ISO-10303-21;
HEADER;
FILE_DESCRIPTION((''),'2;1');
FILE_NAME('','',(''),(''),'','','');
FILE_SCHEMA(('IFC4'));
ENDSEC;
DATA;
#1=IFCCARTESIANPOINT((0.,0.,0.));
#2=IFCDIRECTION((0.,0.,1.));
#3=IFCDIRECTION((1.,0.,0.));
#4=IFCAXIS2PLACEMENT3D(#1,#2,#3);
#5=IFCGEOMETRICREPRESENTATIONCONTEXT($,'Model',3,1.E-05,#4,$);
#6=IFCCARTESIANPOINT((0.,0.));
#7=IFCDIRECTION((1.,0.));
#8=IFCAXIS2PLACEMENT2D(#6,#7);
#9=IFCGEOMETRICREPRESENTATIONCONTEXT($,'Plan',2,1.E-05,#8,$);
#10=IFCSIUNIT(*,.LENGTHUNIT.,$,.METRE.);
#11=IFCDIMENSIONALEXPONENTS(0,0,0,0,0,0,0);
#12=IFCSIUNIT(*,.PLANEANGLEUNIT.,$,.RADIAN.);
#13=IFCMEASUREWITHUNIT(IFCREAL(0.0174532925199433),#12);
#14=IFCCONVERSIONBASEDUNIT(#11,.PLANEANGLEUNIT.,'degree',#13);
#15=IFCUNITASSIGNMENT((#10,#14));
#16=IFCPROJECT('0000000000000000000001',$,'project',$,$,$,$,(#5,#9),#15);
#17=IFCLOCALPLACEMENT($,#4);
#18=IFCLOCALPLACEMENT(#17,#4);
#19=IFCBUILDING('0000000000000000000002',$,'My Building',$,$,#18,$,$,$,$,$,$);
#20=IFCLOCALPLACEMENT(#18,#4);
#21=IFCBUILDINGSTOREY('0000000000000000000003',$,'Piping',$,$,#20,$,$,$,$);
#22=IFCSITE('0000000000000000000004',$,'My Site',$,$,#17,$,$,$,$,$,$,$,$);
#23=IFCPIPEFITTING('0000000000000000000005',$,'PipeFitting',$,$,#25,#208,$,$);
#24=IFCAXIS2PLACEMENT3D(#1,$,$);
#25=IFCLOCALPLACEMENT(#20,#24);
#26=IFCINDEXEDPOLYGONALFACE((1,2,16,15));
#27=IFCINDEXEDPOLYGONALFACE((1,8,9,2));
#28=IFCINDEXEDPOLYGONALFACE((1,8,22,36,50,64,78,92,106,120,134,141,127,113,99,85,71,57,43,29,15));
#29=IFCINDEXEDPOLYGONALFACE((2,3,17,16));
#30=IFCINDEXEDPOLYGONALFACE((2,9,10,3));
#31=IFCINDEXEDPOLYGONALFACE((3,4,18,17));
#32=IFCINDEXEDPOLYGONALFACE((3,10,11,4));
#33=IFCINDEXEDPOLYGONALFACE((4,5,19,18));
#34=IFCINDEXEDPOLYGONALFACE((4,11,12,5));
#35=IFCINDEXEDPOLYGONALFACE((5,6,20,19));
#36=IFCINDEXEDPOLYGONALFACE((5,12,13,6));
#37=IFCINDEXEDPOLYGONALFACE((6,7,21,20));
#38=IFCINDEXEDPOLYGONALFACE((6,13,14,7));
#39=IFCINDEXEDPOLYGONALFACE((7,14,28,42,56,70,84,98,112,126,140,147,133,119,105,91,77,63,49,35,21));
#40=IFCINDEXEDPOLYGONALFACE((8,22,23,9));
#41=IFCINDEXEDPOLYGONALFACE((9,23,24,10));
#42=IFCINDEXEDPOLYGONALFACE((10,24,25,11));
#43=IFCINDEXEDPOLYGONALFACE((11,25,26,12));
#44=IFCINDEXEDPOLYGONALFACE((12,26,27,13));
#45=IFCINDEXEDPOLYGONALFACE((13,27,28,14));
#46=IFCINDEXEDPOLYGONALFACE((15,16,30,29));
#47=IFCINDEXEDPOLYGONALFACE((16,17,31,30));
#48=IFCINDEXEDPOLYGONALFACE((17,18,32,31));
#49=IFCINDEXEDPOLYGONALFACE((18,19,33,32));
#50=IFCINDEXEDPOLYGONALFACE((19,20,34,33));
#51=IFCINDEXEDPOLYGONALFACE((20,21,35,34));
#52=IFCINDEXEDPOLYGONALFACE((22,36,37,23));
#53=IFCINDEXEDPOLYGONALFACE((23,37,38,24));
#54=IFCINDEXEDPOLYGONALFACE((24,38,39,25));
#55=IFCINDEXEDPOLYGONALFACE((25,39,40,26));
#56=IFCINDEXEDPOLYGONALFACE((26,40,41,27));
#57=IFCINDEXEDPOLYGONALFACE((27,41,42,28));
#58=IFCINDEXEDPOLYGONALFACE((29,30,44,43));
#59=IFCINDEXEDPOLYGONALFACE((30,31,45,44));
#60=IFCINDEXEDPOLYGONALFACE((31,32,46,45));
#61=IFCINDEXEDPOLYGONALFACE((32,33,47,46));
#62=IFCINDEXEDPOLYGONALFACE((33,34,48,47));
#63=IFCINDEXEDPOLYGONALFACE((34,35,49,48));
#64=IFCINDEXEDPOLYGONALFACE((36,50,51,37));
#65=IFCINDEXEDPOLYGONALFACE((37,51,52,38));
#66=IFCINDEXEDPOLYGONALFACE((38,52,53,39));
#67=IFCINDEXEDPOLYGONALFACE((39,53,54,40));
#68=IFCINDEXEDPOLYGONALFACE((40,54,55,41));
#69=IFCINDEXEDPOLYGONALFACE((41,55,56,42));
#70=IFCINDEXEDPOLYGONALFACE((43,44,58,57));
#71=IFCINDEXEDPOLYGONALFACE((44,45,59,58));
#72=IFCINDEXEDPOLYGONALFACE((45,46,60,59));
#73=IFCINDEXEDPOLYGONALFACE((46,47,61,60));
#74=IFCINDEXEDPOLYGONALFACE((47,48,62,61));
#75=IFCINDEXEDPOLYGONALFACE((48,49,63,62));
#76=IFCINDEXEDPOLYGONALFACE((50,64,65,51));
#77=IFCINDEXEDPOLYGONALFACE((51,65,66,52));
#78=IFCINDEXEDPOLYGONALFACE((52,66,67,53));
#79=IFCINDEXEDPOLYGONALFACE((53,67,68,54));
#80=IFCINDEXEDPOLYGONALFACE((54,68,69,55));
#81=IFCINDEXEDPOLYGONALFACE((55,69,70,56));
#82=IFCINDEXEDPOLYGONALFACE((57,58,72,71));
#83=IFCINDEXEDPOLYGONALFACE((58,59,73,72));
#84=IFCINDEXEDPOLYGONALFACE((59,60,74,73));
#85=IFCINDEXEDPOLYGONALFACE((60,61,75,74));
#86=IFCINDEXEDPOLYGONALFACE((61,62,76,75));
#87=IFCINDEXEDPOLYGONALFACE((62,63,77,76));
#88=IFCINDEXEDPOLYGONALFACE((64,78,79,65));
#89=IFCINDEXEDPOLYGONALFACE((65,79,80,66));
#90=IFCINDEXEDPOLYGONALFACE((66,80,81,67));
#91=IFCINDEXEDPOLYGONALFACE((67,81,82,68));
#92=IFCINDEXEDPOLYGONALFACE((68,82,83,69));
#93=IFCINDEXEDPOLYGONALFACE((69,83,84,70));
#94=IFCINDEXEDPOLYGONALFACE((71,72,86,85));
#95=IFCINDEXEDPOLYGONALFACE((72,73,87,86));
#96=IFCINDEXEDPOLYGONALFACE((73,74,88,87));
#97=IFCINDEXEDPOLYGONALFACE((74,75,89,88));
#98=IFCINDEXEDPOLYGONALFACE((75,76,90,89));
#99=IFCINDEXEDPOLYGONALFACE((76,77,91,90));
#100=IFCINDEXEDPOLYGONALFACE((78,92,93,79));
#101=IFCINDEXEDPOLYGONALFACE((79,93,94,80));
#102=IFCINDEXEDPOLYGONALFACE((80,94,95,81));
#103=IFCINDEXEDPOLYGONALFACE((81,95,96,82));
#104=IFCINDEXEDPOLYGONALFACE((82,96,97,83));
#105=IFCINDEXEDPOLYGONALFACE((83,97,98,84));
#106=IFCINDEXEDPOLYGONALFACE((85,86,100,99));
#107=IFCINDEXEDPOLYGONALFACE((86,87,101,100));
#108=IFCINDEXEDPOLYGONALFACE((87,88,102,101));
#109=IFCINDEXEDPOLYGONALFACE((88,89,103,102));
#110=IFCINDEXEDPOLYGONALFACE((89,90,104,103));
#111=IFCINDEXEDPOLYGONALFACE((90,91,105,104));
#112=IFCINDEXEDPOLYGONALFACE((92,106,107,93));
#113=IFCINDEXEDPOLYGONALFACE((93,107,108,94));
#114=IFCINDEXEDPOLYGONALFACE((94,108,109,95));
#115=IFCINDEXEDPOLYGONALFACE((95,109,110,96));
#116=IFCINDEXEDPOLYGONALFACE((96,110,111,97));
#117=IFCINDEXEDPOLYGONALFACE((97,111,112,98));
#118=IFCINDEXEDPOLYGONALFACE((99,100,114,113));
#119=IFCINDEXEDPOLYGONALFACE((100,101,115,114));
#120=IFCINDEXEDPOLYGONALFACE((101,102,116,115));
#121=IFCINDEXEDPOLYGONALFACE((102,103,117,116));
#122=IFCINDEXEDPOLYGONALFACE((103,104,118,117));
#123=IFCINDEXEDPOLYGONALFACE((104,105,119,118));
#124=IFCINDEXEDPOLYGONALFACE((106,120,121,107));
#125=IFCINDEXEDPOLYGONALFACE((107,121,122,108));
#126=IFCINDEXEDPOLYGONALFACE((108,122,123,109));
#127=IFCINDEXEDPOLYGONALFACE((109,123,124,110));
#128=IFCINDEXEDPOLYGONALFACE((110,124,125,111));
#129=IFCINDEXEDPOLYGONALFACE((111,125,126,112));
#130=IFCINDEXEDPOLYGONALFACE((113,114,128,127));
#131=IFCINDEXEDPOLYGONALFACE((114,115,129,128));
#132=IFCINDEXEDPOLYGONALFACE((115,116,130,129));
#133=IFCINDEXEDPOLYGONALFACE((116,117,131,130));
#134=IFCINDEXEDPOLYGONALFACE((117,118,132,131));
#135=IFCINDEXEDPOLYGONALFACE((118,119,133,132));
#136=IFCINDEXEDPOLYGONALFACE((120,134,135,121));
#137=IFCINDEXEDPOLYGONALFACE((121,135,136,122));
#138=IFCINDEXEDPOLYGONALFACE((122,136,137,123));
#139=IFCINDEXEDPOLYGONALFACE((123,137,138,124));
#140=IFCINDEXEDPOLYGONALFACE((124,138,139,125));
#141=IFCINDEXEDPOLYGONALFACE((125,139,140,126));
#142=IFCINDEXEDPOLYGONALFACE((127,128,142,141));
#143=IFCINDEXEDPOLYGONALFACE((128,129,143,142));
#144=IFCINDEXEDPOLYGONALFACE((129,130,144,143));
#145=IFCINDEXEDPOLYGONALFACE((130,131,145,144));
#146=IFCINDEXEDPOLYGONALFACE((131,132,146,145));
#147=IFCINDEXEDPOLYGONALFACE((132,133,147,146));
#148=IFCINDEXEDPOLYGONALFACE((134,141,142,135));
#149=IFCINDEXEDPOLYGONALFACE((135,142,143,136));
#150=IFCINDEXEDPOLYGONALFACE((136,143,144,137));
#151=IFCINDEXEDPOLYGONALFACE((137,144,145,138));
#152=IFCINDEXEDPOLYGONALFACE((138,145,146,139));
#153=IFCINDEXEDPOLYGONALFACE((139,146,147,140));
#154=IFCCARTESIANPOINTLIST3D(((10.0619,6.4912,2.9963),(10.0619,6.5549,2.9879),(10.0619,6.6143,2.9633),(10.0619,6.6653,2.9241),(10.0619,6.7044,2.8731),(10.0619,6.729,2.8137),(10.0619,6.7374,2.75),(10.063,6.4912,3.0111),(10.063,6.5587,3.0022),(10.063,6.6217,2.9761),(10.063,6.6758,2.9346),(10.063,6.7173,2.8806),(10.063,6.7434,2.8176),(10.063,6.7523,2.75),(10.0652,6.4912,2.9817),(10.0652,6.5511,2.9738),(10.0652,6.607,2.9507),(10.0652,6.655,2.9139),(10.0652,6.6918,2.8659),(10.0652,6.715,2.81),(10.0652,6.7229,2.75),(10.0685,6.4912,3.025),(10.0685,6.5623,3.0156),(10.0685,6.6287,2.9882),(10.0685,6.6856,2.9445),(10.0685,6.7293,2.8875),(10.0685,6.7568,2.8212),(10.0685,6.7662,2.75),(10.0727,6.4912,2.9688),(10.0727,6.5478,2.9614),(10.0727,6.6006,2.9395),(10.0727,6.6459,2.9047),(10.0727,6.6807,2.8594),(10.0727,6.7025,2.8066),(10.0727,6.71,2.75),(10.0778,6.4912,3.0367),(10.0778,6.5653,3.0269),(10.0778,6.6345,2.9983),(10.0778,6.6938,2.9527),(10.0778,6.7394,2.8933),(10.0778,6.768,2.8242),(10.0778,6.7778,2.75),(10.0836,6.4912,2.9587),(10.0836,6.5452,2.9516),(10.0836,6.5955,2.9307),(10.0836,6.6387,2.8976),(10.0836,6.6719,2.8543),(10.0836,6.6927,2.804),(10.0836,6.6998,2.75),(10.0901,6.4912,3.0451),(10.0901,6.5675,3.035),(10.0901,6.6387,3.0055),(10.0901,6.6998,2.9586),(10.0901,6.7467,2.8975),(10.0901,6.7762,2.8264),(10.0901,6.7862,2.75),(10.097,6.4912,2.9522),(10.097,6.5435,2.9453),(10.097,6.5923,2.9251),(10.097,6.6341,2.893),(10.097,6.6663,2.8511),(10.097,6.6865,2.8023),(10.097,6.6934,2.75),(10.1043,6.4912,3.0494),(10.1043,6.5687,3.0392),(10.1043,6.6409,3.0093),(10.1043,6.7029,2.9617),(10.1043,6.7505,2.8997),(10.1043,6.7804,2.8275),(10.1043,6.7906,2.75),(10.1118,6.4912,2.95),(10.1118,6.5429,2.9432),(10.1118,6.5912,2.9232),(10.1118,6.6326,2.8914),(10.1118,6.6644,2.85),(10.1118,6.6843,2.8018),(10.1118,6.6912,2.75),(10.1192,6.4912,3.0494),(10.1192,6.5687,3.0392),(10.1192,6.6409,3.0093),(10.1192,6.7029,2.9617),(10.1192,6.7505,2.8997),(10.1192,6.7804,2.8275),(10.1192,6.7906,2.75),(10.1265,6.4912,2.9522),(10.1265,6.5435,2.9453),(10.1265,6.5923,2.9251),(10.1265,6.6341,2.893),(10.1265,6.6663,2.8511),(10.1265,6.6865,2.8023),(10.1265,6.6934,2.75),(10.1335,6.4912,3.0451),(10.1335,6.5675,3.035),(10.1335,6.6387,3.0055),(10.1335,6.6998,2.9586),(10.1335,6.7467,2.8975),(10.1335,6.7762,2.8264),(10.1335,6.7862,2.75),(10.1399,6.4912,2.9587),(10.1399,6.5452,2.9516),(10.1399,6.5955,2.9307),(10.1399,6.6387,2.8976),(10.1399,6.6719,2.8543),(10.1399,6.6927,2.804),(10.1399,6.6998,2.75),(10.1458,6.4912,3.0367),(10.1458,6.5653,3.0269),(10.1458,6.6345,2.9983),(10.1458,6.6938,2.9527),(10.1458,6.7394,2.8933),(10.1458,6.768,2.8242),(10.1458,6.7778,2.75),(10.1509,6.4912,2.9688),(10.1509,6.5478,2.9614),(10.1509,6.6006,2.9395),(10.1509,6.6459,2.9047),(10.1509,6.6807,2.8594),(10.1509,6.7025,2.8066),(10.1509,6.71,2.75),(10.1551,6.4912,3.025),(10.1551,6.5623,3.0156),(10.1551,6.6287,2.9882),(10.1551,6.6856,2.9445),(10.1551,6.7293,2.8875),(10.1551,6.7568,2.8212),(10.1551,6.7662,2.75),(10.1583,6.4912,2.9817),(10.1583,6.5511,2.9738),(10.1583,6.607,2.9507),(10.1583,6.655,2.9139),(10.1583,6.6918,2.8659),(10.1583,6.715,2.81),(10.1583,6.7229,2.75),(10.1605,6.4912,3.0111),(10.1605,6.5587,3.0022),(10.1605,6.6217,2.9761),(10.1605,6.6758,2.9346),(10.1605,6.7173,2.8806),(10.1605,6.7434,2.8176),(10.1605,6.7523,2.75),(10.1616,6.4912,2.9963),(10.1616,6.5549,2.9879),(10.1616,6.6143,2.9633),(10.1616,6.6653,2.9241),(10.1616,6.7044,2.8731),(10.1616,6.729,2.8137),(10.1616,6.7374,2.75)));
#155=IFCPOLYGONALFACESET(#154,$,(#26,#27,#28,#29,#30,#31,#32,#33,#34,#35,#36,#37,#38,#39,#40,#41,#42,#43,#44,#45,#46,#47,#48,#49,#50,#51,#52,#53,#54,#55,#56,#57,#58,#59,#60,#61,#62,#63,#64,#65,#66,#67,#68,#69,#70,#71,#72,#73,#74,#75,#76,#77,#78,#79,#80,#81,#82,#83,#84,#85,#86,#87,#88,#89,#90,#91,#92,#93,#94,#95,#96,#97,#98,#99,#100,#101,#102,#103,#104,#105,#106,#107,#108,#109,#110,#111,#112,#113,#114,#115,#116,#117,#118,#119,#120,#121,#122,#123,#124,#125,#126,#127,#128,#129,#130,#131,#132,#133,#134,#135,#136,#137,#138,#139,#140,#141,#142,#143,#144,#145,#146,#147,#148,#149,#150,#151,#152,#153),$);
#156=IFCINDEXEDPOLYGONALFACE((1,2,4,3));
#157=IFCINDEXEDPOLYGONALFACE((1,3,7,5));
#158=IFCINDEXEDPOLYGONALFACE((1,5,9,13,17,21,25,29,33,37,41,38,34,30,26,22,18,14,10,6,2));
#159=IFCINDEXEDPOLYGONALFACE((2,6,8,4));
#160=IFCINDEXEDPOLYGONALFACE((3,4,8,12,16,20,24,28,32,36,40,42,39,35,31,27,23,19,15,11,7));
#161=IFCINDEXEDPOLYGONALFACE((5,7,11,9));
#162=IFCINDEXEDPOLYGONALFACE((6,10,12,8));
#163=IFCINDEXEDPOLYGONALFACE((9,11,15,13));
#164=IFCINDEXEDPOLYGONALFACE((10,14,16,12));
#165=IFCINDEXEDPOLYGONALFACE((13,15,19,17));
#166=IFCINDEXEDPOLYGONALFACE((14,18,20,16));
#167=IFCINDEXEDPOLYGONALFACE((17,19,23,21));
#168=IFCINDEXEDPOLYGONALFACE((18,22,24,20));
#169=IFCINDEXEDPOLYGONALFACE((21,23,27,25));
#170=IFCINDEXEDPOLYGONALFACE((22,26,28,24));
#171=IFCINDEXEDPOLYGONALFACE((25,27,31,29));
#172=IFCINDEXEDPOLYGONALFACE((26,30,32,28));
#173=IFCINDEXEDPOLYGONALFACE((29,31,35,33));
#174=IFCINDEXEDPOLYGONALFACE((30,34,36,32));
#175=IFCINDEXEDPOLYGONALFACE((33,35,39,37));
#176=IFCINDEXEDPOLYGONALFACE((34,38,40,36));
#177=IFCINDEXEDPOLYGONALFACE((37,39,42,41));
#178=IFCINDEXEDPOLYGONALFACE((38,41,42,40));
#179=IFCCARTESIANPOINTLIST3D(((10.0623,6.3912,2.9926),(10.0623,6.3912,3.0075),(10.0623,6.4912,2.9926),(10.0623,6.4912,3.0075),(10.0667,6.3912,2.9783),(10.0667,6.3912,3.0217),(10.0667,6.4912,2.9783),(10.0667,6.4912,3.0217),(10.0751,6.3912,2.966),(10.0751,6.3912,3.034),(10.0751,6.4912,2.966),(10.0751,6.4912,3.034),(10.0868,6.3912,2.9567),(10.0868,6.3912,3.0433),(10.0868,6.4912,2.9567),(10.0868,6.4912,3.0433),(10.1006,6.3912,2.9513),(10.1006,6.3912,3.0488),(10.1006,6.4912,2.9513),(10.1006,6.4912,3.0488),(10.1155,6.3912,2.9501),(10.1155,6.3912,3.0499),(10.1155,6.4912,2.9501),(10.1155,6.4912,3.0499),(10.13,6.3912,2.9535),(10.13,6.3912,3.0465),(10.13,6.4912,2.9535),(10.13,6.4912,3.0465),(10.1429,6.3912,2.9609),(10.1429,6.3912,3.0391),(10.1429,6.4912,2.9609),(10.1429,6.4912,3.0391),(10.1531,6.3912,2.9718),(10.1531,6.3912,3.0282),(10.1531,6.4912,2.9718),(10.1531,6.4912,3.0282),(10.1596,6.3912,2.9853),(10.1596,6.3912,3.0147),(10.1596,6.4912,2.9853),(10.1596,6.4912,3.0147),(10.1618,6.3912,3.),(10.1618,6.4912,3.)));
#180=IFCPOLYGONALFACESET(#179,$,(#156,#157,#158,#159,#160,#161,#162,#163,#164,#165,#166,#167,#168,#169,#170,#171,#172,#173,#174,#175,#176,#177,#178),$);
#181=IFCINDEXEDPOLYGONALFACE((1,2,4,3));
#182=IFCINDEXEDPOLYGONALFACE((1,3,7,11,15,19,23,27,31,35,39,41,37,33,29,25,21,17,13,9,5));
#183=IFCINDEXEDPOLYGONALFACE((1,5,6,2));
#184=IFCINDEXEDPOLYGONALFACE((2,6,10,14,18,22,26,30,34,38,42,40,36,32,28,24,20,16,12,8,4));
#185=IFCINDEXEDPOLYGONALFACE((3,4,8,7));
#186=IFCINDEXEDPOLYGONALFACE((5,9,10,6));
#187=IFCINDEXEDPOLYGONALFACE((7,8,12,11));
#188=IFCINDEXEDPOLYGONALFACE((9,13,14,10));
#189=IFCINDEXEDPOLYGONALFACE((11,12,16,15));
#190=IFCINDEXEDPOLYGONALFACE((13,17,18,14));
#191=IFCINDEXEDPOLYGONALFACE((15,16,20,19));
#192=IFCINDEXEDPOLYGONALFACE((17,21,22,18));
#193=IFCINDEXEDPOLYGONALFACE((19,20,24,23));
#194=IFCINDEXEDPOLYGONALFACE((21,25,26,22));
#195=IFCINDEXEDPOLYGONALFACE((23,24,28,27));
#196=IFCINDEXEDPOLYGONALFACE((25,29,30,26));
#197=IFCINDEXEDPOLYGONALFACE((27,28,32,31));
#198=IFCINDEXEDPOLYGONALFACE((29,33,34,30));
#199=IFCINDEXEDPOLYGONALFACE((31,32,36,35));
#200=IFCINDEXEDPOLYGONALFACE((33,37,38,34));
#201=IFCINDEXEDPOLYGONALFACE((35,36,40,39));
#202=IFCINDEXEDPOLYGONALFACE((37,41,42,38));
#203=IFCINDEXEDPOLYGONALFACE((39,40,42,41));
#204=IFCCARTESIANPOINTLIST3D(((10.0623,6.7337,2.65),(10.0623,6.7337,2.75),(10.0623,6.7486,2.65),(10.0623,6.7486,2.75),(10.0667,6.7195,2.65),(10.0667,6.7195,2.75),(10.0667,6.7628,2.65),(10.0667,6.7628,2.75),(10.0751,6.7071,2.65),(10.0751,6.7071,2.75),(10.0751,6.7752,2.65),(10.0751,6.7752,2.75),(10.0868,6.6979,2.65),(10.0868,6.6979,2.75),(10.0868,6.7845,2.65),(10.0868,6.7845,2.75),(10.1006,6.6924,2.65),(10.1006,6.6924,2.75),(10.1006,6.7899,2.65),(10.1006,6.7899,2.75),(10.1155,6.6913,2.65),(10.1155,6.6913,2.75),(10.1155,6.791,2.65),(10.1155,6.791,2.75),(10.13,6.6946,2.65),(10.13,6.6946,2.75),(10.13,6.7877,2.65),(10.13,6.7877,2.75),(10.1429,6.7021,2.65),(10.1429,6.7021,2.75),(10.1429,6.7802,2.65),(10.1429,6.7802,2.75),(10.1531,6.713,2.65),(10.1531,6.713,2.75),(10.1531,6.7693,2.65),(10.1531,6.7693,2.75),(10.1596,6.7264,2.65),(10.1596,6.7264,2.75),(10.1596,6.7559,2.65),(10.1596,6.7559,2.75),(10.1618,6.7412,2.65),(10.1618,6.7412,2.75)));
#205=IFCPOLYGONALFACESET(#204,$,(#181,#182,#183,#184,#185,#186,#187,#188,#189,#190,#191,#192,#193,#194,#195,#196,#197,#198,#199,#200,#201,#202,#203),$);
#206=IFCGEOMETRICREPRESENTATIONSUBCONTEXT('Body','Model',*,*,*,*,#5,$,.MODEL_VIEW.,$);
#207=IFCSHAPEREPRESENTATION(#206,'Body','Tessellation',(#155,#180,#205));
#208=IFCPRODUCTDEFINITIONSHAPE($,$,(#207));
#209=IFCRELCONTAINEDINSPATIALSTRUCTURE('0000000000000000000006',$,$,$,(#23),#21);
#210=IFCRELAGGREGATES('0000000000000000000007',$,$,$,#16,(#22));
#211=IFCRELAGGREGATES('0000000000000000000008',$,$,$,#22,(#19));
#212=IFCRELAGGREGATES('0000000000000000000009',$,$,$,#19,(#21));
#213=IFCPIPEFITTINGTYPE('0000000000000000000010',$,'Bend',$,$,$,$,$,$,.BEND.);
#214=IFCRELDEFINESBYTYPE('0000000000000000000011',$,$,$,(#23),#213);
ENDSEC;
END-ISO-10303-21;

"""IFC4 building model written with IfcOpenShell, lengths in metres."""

from ifc_helpers import new_model, entity, si_unit, converted_unit, frame, origin_with_axes, origin_2d_with_axis, place, context, subcontext, project, spatial, circle, extrude, source, transform, mapped, type_object, type_shapes, element, save


model = new_model("IFC4")

# Units and contexts
model_context = context("Model", 3, precision=1e-05, world=origin_with_axes())
plan_context = context("Plan", 2, precision=1e-05, world=origin_2d_with_axis())
body_context = subcontext(model_context, "Body", "Model", "MODEL_VIEW")
ifc_project = project(units=[si_unit("LENGTHUNIT", "METRE"), converted_unit("PLANEANGLEUNIT", "degree", entity("IfcReal", 0.0174532925199433), si_unit("PLANEANGLEUNIT", "RADIAN"), dimensions=[0, 0, 0, 0, 0, 0, 0])], contexts=[model_context, plan_context])

# Site, building, storey
site_placement = place(None, origin_with_axes())
site = spatial("IfcSite", under=ifc_project, at=site_placement, Name="My Site")
building_placement = place(site_placement, origin_with_axes())
building = spatial("IfcBuilding", under=site, at=building_placement, Name="My Building")
storey_placement = place(building_placement, origin_with_axes())
storey = spatial("IfcBuildingStorey", under=building, at=storey_placement, Name="Piping")

# Pipe fitting
pipe_fitting_type = type_object("IfcPipeFittingType", Name="Bend", PredefinedType="BEND")
shared_shape = source(origin_with_axes(), body_context, "Body", "SolidModel", [
    entity("IfcSweptDiskSolid", entity("IfcIndexedPolyCurve", entity("IfcCartesianPointList3D", [[0.0, 0.0, -0.1], [0.0, -0.0732, -0.2768], [0.0, -0.25, -0.35]]), [entity("IfcArcIndex", [1, 2, 3])]), 0.05),
    extrude(circle(Radius=0.05), origin_with_axes(), (0.0, 0.0, -1.0), 0.1),
    extrude(circle(Radius=0.05), frame((0.0, -0.25, -0.35), z_axis=(0.0, -1.0, 0.0), x_axis=(1.0, 0.0, 0.0)), (0.0, 0.0, 1.0), 0.1),
])
type_shapes(pipe_fitting_type, [shared_shape])
for number, where, z_axis, x_axis, name in (
    (1, (10.1118, 6.3912, 3.0), (0.0, -1.0, 0.0), (1.0, 0.0, 0.0), "PipeFitting"),
):
    element("IfcPipeFitting", number, at=place(storey_placement, frame(where, z_axis=z_axis, x_axis=x_axis)), inside=storey, type_object=pipe_fitting_type, Name=name, context=body_context, shape_type="MappedRepresentation", body=[
        mapped(shared_shape, transform((0.0, 0.0, 0.0), x_axis=(1.0, 0.0, 0.0), y_axis=(0.0, 1.0, 0.0), z_axis=(0.0, 0.0, 1.0), scale=1.0)),
    ])

save(model, "model.ifc")
